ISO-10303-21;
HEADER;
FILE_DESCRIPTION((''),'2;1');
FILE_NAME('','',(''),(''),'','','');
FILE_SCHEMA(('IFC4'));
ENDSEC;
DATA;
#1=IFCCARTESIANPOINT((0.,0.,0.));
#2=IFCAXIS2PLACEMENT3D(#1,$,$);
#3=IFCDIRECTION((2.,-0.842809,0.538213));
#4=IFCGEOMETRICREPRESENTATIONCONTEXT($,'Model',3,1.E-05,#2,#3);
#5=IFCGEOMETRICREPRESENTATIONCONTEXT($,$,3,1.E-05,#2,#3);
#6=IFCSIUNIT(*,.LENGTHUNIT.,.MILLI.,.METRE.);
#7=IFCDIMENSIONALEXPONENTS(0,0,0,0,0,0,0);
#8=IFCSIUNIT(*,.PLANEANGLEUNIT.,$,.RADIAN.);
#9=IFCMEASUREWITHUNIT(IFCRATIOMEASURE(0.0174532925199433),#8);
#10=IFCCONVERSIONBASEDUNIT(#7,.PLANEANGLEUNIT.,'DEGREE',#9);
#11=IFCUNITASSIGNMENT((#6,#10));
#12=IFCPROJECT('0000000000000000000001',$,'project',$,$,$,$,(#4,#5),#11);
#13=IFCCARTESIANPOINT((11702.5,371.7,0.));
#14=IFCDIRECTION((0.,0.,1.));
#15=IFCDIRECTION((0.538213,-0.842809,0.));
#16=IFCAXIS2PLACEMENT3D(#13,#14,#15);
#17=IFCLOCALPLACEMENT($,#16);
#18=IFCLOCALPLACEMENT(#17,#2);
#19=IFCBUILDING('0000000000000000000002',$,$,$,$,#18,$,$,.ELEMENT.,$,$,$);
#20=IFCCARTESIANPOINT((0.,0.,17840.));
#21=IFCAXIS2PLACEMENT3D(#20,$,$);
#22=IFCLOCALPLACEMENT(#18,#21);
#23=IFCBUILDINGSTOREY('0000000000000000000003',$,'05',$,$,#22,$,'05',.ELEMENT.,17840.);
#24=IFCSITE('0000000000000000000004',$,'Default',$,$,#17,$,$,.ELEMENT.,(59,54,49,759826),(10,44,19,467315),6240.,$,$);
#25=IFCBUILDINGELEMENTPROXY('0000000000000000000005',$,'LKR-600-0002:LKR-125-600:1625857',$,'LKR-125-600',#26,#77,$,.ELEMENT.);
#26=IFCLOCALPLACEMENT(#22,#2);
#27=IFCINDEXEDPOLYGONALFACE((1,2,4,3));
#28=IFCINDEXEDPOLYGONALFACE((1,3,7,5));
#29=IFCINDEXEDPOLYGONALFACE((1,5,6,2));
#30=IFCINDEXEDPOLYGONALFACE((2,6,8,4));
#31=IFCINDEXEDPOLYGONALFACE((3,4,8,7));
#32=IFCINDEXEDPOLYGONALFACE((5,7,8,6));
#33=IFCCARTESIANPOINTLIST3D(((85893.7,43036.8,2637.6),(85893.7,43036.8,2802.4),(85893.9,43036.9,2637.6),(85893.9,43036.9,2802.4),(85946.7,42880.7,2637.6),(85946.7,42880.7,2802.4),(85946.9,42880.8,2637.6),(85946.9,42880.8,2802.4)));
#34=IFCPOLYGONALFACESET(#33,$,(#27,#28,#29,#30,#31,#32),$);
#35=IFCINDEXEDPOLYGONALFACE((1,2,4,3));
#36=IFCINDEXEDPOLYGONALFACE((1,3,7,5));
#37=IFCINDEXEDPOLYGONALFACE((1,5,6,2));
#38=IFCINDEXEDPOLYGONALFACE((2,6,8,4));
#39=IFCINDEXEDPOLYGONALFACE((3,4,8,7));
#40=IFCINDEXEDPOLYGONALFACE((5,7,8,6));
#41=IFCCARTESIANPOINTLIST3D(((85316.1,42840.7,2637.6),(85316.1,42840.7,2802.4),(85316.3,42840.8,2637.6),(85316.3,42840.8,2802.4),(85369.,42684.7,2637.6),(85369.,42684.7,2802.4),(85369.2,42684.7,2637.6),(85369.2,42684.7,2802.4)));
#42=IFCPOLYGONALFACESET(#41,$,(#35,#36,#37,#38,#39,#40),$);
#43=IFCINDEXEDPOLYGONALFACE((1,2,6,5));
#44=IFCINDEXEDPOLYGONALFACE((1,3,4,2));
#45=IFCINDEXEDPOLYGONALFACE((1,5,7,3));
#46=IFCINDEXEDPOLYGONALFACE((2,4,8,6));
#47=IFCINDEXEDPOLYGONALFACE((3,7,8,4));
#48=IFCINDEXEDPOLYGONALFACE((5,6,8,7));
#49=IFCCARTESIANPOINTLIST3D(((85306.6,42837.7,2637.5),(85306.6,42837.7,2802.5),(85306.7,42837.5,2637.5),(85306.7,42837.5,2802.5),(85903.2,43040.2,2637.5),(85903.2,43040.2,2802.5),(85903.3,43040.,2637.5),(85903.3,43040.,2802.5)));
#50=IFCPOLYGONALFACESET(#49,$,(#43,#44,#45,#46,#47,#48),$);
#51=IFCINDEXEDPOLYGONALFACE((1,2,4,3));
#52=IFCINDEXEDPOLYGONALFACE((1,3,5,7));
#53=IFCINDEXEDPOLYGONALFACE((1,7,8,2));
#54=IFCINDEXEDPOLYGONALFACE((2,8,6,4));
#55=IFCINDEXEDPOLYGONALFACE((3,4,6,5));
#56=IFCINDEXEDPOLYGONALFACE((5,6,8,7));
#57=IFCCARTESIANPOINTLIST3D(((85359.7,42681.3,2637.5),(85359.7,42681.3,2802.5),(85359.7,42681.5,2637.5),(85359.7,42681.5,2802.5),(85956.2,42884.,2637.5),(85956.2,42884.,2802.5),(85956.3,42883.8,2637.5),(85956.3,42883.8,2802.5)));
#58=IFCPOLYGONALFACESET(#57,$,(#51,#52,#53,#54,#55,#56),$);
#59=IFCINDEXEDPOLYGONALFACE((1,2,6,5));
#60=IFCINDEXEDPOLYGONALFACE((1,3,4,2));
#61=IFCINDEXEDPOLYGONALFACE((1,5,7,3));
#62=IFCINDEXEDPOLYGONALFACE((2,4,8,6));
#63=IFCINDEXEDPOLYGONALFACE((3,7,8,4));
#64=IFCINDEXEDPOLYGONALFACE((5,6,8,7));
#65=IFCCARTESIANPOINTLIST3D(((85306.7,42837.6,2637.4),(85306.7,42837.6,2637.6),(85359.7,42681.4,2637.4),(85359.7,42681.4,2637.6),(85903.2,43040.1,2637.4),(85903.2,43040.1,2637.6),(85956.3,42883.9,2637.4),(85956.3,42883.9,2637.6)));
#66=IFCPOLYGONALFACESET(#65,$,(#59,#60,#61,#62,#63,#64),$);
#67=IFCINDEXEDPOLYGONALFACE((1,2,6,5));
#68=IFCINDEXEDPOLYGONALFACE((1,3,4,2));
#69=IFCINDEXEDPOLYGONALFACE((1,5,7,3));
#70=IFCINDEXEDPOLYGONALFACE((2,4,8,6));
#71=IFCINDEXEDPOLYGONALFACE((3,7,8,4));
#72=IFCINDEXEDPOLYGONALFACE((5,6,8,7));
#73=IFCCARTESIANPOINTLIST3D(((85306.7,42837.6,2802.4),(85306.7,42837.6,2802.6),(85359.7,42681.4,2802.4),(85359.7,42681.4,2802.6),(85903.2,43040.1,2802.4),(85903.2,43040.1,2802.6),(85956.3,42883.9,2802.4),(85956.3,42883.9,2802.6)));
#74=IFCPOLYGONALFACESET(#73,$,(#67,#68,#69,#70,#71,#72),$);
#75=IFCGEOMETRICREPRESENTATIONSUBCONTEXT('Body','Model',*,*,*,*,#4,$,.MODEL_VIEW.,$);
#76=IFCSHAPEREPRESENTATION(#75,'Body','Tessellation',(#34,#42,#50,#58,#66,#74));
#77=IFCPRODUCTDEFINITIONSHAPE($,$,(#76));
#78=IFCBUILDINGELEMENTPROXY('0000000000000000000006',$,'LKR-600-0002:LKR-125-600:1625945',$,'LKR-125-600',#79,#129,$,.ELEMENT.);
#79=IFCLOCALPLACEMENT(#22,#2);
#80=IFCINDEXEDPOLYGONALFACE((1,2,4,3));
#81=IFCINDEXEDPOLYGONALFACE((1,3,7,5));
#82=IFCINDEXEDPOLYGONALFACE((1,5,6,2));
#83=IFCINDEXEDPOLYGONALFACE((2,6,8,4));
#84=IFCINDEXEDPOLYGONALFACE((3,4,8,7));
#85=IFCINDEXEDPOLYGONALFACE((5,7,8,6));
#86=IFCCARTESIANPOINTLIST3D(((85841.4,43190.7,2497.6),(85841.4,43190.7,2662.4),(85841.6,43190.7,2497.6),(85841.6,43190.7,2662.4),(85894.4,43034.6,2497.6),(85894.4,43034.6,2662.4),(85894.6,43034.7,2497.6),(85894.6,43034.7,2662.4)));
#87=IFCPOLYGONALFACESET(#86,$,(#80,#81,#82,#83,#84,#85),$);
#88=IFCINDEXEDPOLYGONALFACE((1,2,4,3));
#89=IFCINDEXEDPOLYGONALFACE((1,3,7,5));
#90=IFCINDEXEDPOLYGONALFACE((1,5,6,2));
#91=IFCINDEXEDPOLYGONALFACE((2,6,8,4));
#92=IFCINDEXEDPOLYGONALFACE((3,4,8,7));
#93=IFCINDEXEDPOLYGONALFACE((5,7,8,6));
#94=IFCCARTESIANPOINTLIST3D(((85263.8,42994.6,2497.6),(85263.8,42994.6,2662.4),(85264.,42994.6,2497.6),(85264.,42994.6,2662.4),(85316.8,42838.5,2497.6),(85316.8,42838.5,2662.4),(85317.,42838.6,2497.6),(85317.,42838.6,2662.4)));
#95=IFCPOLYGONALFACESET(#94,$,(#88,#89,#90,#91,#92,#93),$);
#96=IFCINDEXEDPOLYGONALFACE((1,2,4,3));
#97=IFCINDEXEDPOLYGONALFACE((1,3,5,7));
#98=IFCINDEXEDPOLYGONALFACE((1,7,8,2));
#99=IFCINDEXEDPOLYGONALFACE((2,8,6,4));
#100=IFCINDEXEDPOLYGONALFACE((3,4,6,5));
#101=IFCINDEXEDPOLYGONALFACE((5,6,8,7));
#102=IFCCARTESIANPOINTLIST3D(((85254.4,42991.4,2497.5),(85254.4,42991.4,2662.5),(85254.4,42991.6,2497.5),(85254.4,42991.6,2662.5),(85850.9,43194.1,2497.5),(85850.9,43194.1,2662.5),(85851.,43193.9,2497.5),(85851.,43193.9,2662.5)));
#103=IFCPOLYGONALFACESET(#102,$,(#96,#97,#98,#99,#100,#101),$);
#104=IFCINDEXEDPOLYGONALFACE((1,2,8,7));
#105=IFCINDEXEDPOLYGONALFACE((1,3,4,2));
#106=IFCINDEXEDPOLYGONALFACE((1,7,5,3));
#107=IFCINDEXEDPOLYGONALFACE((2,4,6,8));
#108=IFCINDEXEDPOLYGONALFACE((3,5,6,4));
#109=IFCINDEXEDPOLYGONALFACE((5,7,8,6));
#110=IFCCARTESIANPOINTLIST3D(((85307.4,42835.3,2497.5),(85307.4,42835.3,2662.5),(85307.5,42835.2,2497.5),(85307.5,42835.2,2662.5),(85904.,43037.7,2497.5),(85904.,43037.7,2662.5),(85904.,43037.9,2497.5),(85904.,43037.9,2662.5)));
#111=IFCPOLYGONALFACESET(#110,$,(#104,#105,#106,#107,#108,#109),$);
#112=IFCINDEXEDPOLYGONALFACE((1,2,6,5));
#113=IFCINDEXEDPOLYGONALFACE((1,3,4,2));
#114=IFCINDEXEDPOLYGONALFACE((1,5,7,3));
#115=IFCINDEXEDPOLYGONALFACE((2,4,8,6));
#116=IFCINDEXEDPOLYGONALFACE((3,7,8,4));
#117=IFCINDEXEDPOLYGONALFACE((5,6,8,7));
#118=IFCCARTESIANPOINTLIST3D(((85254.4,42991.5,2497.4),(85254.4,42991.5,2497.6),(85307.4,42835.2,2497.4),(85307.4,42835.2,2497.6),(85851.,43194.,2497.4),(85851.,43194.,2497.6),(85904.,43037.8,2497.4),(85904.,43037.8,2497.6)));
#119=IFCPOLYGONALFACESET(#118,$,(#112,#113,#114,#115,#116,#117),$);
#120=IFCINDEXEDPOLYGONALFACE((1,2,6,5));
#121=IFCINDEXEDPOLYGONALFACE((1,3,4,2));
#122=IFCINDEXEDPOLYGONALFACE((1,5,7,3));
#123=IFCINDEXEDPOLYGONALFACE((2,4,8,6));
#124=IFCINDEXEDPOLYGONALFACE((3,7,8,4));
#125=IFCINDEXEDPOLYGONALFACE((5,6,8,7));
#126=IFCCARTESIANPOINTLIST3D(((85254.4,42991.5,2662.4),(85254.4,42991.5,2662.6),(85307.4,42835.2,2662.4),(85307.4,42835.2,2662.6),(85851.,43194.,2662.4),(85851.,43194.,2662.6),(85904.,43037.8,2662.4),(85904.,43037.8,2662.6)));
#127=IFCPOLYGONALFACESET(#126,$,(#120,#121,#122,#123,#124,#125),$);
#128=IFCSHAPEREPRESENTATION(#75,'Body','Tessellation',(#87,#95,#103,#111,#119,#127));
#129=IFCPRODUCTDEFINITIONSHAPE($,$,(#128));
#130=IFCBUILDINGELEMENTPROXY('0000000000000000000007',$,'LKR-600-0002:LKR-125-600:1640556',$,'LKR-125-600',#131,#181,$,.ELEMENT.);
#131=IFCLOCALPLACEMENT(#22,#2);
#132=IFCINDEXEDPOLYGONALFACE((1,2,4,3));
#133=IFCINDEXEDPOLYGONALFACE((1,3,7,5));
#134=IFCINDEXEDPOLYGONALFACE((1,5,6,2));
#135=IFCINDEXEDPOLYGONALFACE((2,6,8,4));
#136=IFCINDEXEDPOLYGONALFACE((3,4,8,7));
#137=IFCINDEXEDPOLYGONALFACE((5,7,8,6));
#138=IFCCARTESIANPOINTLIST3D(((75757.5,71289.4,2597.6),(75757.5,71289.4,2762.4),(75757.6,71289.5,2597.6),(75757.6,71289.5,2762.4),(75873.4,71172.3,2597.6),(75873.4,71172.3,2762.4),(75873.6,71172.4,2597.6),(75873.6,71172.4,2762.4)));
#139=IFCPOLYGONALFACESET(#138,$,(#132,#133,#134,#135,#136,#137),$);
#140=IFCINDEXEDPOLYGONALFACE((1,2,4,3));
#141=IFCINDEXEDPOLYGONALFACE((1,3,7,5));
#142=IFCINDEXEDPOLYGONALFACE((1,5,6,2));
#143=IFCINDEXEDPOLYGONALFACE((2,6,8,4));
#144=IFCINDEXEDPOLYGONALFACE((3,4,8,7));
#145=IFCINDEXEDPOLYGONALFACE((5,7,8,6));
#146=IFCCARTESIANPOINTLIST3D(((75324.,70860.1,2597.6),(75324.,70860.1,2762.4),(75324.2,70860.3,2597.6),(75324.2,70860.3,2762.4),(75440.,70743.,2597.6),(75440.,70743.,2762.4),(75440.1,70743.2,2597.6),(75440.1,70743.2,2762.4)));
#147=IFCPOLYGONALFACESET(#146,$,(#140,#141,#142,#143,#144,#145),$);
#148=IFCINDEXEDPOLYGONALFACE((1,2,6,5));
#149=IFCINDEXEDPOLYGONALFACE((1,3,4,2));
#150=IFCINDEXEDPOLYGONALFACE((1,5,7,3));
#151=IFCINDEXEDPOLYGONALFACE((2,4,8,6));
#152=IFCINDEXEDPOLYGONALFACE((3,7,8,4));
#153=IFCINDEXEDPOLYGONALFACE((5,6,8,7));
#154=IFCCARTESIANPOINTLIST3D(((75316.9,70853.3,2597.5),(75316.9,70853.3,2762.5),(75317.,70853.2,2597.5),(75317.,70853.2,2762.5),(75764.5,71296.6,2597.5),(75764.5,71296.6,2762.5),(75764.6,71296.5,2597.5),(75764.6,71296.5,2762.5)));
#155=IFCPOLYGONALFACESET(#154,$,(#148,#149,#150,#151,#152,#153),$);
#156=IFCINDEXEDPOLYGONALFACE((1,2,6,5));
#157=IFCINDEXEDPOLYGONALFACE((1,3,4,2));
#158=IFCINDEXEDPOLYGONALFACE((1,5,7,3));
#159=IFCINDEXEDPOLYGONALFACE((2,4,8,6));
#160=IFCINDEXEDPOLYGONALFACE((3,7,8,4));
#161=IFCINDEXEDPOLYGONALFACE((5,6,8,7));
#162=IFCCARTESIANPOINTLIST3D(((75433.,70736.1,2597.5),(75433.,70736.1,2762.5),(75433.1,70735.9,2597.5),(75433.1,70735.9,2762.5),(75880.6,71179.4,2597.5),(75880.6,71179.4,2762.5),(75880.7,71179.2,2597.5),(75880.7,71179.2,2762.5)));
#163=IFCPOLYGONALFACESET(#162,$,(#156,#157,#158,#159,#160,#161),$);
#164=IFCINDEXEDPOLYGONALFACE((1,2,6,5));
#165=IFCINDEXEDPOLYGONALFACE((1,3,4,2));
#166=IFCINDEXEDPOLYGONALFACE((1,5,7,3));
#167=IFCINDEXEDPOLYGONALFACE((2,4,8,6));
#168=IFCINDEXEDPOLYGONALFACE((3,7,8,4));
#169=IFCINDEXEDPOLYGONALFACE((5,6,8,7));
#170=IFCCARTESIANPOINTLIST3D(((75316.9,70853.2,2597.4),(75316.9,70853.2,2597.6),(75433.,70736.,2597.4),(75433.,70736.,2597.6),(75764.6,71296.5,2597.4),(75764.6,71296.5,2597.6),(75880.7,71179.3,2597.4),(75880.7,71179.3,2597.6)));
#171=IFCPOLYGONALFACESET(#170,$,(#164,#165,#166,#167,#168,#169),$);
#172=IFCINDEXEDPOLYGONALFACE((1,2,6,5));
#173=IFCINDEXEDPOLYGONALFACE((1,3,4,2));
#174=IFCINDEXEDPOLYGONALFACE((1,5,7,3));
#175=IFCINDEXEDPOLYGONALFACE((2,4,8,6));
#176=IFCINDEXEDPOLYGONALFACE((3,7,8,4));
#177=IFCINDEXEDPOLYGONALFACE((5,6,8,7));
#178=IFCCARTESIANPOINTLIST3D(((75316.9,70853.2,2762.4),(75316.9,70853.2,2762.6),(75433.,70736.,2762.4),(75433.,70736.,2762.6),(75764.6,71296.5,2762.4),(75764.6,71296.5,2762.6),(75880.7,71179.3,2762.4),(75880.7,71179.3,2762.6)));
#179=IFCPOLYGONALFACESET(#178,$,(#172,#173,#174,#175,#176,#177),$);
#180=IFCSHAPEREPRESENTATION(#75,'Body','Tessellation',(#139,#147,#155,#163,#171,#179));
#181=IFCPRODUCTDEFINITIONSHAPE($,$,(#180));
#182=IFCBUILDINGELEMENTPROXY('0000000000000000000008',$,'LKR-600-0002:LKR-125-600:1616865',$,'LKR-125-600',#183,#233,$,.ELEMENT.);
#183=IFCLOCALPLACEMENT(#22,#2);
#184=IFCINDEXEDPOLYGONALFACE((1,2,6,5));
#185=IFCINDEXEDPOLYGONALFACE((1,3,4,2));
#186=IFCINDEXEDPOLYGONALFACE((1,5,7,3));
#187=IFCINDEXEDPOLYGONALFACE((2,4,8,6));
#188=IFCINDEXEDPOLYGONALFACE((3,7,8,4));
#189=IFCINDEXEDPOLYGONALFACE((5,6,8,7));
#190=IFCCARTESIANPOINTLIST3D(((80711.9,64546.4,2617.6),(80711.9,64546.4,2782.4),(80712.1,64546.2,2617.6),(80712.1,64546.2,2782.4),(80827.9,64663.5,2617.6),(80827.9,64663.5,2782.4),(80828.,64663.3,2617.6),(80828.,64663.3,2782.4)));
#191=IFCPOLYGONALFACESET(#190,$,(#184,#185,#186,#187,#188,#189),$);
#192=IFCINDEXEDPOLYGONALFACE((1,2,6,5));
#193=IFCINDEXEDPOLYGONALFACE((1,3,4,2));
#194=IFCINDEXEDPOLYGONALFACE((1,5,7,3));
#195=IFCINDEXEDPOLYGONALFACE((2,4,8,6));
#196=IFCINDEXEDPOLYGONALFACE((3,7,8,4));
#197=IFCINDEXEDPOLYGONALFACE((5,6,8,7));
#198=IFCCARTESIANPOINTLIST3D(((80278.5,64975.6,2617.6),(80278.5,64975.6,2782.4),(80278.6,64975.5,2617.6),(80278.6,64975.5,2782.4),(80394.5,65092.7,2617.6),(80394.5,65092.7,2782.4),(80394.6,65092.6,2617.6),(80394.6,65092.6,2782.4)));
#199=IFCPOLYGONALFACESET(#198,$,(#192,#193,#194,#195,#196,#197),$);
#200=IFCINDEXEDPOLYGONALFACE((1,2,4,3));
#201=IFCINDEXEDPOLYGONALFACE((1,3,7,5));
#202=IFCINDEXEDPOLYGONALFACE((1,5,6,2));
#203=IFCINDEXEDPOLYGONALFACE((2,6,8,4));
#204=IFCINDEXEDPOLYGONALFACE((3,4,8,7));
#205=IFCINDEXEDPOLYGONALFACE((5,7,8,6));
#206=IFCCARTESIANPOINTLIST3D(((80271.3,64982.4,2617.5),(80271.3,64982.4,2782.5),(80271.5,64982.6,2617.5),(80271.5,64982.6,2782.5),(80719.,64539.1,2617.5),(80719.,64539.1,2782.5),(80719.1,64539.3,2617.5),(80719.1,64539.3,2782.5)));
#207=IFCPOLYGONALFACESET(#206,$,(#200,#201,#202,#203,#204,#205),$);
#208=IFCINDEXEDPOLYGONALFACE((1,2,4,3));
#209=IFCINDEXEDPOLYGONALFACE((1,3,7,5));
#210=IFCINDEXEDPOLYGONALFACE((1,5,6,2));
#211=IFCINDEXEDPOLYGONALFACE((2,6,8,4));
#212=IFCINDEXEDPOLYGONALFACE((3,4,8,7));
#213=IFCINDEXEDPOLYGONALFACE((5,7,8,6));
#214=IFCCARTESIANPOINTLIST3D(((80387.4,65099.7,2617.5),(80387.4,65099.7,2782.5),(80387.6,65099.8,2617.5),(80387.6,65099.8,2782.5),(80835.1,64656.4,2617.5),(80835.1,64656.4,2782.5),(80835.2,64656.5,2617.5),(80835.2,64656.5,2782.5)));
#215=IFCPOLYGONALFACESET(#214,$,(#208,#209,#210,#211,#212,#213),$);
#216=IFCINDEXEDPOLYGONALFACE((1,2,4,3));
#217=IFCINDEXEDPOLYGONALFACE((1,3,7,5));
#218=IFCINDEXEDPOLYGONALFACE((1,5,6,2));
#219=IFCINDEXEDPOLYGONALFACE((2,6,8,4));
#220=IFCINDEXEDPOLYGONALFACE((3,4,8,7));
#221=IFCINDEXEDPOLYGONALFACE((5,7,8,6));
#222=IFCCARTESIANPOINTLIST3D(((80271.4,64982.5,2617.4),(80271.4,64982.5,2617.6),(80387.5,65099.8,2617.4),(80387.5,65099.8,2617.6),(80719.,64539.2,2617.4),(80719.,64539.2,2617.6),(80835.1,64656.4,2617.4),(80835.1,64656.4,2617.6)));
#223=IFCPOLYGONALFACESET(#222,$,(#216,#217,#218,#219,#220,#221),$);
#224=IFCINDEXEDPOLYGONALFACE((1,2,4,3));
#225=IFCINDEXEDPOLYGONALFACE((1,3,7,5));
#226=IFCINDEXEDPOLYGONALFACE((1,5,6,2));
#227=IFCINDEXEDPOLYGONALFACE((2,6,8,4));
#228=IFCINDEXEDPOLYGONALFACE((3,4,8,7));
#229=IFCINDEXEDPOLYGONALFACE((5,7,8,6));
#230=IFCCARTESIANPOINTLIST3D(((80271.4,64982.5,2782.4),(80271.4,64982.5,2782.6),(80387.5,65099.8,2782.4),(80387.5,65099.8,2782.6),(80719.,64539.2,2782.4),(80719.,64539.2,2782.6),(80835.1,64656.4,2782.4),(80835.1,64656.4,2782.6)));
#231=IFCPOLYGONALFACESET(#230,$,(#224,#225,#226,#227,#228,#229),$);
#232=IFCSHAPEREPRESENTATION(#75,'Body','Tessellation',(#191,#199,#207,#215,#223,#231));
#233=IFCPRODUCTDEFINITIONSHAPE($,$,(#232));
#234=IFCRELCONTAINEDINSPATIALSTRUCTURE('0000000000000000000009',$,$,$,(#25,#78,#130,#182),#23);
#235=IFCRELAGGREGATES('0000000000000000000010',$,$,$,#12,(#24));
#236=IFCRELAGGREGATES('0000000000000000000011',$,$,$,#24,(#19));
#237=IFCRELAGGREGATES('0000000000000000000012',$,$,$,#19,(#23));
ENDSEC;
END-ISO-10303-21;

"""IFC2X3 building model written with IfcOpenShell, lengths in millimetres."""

from ifc_helpers import new_model, entity, si_unit, converted_unit, direction, frame, frame_2d, origin, place, context, subcontext, project, spatial, rectangle, extrude, source, transform, mapped, element, save


model = new_model("IFC2X3")

# Units and contexts
model_context = context("Model", 3, precision=1e-05, world=origin(), true_north=direction((2.0, -0.842809, 0.538213)))
context_of_model = context(None, 3, precision=1e-05, world=origin(), true_north=direction((2.0, -0.842809, 0.538213)))
body_context = subcontext(model_context, "Body", "Model", "MODEL_VIEW")
ifc_project = project(units=[si_unit("LENGTHUNIT", "METRE", prefix="MILLI"), converted_unit("PLANEANGLEUNIT", "DEGREE", entity("IfcRatioMeasure", 0.0174532925199433), si_unit("PLANEANGLEUNIT", "RADIAN"), dimensions=[0, 0, 0, 0, 0, 0, 0])], contexts=[model_context, context_of_model])

# Site, building, storey
site_placement = place(None, frame((11702.5, 371.7, 0.0), z_axis=(0.0, 0.0, 1.0), x_axis=(0.538213, -0.842809, 0.0)))
site = spatial("IfcSite", under=ifc_project, at=site_placement, Name="Default", CompositionType="ELEMENT", RefLatitude=(59, 54, 49, 759826), RefLongitude=(10, 44, 19, 467315), RefElevation=6240.0)
building_placement = place(site_placement, origin())
building = spatial("IfcBuilding", under=site, at=building_placement, CompositionType="ELEMENT")
storey_placement = place(building_placement, frame((0.0, 0.0, 17840.0)))
storey = spatial("IfcBuildingStorey", under=building, at=storey_placement, Name="05", LongName="05", CompositionType="ELEMENT", Elevation=17840.0)

# Building element proxies
shared_shape_1 = source(origin(), body_context, "Body", "SweptSolid", [
    extrude(rectangle(XDim=0.2, YDim=164.8, at=frame_2d((0.0, 0.0), x_axis=(1.0, 0.0))), frame((305.0, 0.0, -82.4)), (0.0, 0.0, 1.0), 164.8),
    extrude(rectangle(XDim=0.2, YDim=164.8, at=frame_2d((0.0, 0.0), x_axis=(1.0, 0.0))), frame((-305.0, 0.0, -82.4)), (0.0, 0.0, 1.0), 164.8),
    extrude(rectangle(XDim=0.2, YDim=630.0, at=frame_2d((0.0, 0.0), x_axis=(1.0, 0.0))), frame((0.0, 82.5, -82.5), z_axis=(0.0, 0.0, 1.0), x_axis=(0.0, 1.0, 0.0)), (0.0, 0.0, 1.0), 165.0),
    extrude(rectangle(XDim=0.2, YDim=630.0, at=frame_2d((0.0, 0.0), x_axis=(1.0, 0.0))), frame((0.0, -82.5, -82.5), z_axis=(0.0, 0.0, 1.0), x_axis=(0.0, 1.0, 0.0)), (0.0, 0.0, 1.0), 165.0),
    extrude(rectangle(XDim=165.0, YDim=630.0, at=frame_2d((0.0, 0.0), x_axis=(1.0, 0.0))), frame((0.0, 0.0, -82.6), z_axis=(0.0, 0.0, 1.0), x_axis=(0.0, -1.0, 0.0)), (0.0, 0.0, 1.0), 0.2),
    extrude(rectangle(XDim=165.0, YDim=630.0, at=frame_2d((0.0, 0.0), x_axis=(1.0, 0.0))), frame((0.0, 0.0, 82.4), z_axis=(0.0, 0.0, 1.0), x_axis=(0.0, -1.0, 0.0)), (0.0, 0.0, 1.0), 0.2),
])
for number, where, z_axis, x_axis, name in (
    (1, (85631.5, 42860.8, 2720.0), (0.0, 0.0, 1.0), (0.94693, 0.321439, 0.0), "LKR-600-0002:LKR-125-600:1625857"),
    (2, (85579.2, 43014.6, 2580.0), (0.0, 0.0, 1.0), (0.94693, 0.321439, 0.0), "LKR-600-0002:LKR-125-600:1625945"),
    (3, (75598.8, 71016.3, 2680.0), (0.0, 0.0, 1.0), (0.710554, 0.703643, 0.0), "LKR-600-0002:LKR-125-600:1640556"),
):
    element("IfcBuildingElementProxy", number, at=place(storey_placement, frame(where, z_axis=z_axis, x_axis=x_axis)), inside=storey, Name=name, ObjectType="LKR-125-600", CompositionType="ELEMENT", context=body_context, shape_type="MappedRepresentation", body=[
        mapped(shared_shape_1, transform((0.0, 0.0, 0.0), scale=1.0)),
    ])
shared_shape_2 = source(origin(), body_context, "Body", "SweptSolid", [
    extrude(rectangle(XDim=164.8, YDim=0.2, at=frame_2d((0.0, 0.0), x_axis=(1.0, 0.0))), frame((305.0, 0.0, -82.4), z_axis=(0.0, 0.0, 1.0), x_axis=(0.0, -1.0, 0.0)), (0.0, 0.0, 1.0), 164.8),
    extrude(rectangle(XDim=164.8, YDim=0.2, at=frame_2d((0.0, 0.0), x_axis=(1.0, 0.0))), frame((-305.0, 0.0, -82.4), z_axis=(0.0, 0.0, 1.0), x_axis=(0.0, -1.0, 0.0)), (0.0, 0.0, 1.0), 164.8),
    extrude(rectangle(XDim=630.0, YDim=0.2, at=frame_2d((0.0, 0.0), x_axis=(1.0, 0.0))), frame((0.0, -82.5, -82.5), z_axis=(0.0, 0.0, 1.0), x_axis=(-1.0, 0.0, 0.0)), (0.0, 0.0, 1.0), 165.0),
    extrude(rectangle(XDim=630.0, YDim=0.2, at=frame_2d((0.0, 0.0), x_axis=(1.0, 0.0))), frame((0.0, 82.5, -82.5), z_axis=(0.0, 0.0, 1.0), x_axis=(-1.0, 0.0, 0.0)), (0.0, 0.0, 1.0), 165.0),
    extrude(rectangle(XDim=630.0, YDim=165.0, at=frame_2d((0.0, 0.0), x_axis=(1.0, 0.0))), frame((0.0, 0.0, -82.6)), (0.0, 0.0, 1.0), 0.2),
    extrude(rectangle(XDim=630.0, YDim=165.0, at=frame_2d((0.0, 0.0), x_axis=(1.0, 0.0))), frame((0.0, 0.0, 82.4)), (0.0, 0.0, 1.0), 0.2),
])
proxy_1_placement = place(storey_placement, frame((80553.3, 64819.5, 2700.0), z_axis=(0.0, 0.0, 1.0), x_axis=(0.710528, -0.703669, 0.0)))
element("IfcBuildingElementProxy", 4, at=proxy_1_placement, inside=storey, Name="LKR-600-0002:LKR-125-600:1616865", ObjectType="LKR-125-600", CompositionType="ELEMENT", context=body_context, shape_type="MappedRepresentation", body=[
    mapped(shared_shape_2, transform((0.0, 0.0, 0.0), scale=1.0)),
])

save(model, "model.ifc")
